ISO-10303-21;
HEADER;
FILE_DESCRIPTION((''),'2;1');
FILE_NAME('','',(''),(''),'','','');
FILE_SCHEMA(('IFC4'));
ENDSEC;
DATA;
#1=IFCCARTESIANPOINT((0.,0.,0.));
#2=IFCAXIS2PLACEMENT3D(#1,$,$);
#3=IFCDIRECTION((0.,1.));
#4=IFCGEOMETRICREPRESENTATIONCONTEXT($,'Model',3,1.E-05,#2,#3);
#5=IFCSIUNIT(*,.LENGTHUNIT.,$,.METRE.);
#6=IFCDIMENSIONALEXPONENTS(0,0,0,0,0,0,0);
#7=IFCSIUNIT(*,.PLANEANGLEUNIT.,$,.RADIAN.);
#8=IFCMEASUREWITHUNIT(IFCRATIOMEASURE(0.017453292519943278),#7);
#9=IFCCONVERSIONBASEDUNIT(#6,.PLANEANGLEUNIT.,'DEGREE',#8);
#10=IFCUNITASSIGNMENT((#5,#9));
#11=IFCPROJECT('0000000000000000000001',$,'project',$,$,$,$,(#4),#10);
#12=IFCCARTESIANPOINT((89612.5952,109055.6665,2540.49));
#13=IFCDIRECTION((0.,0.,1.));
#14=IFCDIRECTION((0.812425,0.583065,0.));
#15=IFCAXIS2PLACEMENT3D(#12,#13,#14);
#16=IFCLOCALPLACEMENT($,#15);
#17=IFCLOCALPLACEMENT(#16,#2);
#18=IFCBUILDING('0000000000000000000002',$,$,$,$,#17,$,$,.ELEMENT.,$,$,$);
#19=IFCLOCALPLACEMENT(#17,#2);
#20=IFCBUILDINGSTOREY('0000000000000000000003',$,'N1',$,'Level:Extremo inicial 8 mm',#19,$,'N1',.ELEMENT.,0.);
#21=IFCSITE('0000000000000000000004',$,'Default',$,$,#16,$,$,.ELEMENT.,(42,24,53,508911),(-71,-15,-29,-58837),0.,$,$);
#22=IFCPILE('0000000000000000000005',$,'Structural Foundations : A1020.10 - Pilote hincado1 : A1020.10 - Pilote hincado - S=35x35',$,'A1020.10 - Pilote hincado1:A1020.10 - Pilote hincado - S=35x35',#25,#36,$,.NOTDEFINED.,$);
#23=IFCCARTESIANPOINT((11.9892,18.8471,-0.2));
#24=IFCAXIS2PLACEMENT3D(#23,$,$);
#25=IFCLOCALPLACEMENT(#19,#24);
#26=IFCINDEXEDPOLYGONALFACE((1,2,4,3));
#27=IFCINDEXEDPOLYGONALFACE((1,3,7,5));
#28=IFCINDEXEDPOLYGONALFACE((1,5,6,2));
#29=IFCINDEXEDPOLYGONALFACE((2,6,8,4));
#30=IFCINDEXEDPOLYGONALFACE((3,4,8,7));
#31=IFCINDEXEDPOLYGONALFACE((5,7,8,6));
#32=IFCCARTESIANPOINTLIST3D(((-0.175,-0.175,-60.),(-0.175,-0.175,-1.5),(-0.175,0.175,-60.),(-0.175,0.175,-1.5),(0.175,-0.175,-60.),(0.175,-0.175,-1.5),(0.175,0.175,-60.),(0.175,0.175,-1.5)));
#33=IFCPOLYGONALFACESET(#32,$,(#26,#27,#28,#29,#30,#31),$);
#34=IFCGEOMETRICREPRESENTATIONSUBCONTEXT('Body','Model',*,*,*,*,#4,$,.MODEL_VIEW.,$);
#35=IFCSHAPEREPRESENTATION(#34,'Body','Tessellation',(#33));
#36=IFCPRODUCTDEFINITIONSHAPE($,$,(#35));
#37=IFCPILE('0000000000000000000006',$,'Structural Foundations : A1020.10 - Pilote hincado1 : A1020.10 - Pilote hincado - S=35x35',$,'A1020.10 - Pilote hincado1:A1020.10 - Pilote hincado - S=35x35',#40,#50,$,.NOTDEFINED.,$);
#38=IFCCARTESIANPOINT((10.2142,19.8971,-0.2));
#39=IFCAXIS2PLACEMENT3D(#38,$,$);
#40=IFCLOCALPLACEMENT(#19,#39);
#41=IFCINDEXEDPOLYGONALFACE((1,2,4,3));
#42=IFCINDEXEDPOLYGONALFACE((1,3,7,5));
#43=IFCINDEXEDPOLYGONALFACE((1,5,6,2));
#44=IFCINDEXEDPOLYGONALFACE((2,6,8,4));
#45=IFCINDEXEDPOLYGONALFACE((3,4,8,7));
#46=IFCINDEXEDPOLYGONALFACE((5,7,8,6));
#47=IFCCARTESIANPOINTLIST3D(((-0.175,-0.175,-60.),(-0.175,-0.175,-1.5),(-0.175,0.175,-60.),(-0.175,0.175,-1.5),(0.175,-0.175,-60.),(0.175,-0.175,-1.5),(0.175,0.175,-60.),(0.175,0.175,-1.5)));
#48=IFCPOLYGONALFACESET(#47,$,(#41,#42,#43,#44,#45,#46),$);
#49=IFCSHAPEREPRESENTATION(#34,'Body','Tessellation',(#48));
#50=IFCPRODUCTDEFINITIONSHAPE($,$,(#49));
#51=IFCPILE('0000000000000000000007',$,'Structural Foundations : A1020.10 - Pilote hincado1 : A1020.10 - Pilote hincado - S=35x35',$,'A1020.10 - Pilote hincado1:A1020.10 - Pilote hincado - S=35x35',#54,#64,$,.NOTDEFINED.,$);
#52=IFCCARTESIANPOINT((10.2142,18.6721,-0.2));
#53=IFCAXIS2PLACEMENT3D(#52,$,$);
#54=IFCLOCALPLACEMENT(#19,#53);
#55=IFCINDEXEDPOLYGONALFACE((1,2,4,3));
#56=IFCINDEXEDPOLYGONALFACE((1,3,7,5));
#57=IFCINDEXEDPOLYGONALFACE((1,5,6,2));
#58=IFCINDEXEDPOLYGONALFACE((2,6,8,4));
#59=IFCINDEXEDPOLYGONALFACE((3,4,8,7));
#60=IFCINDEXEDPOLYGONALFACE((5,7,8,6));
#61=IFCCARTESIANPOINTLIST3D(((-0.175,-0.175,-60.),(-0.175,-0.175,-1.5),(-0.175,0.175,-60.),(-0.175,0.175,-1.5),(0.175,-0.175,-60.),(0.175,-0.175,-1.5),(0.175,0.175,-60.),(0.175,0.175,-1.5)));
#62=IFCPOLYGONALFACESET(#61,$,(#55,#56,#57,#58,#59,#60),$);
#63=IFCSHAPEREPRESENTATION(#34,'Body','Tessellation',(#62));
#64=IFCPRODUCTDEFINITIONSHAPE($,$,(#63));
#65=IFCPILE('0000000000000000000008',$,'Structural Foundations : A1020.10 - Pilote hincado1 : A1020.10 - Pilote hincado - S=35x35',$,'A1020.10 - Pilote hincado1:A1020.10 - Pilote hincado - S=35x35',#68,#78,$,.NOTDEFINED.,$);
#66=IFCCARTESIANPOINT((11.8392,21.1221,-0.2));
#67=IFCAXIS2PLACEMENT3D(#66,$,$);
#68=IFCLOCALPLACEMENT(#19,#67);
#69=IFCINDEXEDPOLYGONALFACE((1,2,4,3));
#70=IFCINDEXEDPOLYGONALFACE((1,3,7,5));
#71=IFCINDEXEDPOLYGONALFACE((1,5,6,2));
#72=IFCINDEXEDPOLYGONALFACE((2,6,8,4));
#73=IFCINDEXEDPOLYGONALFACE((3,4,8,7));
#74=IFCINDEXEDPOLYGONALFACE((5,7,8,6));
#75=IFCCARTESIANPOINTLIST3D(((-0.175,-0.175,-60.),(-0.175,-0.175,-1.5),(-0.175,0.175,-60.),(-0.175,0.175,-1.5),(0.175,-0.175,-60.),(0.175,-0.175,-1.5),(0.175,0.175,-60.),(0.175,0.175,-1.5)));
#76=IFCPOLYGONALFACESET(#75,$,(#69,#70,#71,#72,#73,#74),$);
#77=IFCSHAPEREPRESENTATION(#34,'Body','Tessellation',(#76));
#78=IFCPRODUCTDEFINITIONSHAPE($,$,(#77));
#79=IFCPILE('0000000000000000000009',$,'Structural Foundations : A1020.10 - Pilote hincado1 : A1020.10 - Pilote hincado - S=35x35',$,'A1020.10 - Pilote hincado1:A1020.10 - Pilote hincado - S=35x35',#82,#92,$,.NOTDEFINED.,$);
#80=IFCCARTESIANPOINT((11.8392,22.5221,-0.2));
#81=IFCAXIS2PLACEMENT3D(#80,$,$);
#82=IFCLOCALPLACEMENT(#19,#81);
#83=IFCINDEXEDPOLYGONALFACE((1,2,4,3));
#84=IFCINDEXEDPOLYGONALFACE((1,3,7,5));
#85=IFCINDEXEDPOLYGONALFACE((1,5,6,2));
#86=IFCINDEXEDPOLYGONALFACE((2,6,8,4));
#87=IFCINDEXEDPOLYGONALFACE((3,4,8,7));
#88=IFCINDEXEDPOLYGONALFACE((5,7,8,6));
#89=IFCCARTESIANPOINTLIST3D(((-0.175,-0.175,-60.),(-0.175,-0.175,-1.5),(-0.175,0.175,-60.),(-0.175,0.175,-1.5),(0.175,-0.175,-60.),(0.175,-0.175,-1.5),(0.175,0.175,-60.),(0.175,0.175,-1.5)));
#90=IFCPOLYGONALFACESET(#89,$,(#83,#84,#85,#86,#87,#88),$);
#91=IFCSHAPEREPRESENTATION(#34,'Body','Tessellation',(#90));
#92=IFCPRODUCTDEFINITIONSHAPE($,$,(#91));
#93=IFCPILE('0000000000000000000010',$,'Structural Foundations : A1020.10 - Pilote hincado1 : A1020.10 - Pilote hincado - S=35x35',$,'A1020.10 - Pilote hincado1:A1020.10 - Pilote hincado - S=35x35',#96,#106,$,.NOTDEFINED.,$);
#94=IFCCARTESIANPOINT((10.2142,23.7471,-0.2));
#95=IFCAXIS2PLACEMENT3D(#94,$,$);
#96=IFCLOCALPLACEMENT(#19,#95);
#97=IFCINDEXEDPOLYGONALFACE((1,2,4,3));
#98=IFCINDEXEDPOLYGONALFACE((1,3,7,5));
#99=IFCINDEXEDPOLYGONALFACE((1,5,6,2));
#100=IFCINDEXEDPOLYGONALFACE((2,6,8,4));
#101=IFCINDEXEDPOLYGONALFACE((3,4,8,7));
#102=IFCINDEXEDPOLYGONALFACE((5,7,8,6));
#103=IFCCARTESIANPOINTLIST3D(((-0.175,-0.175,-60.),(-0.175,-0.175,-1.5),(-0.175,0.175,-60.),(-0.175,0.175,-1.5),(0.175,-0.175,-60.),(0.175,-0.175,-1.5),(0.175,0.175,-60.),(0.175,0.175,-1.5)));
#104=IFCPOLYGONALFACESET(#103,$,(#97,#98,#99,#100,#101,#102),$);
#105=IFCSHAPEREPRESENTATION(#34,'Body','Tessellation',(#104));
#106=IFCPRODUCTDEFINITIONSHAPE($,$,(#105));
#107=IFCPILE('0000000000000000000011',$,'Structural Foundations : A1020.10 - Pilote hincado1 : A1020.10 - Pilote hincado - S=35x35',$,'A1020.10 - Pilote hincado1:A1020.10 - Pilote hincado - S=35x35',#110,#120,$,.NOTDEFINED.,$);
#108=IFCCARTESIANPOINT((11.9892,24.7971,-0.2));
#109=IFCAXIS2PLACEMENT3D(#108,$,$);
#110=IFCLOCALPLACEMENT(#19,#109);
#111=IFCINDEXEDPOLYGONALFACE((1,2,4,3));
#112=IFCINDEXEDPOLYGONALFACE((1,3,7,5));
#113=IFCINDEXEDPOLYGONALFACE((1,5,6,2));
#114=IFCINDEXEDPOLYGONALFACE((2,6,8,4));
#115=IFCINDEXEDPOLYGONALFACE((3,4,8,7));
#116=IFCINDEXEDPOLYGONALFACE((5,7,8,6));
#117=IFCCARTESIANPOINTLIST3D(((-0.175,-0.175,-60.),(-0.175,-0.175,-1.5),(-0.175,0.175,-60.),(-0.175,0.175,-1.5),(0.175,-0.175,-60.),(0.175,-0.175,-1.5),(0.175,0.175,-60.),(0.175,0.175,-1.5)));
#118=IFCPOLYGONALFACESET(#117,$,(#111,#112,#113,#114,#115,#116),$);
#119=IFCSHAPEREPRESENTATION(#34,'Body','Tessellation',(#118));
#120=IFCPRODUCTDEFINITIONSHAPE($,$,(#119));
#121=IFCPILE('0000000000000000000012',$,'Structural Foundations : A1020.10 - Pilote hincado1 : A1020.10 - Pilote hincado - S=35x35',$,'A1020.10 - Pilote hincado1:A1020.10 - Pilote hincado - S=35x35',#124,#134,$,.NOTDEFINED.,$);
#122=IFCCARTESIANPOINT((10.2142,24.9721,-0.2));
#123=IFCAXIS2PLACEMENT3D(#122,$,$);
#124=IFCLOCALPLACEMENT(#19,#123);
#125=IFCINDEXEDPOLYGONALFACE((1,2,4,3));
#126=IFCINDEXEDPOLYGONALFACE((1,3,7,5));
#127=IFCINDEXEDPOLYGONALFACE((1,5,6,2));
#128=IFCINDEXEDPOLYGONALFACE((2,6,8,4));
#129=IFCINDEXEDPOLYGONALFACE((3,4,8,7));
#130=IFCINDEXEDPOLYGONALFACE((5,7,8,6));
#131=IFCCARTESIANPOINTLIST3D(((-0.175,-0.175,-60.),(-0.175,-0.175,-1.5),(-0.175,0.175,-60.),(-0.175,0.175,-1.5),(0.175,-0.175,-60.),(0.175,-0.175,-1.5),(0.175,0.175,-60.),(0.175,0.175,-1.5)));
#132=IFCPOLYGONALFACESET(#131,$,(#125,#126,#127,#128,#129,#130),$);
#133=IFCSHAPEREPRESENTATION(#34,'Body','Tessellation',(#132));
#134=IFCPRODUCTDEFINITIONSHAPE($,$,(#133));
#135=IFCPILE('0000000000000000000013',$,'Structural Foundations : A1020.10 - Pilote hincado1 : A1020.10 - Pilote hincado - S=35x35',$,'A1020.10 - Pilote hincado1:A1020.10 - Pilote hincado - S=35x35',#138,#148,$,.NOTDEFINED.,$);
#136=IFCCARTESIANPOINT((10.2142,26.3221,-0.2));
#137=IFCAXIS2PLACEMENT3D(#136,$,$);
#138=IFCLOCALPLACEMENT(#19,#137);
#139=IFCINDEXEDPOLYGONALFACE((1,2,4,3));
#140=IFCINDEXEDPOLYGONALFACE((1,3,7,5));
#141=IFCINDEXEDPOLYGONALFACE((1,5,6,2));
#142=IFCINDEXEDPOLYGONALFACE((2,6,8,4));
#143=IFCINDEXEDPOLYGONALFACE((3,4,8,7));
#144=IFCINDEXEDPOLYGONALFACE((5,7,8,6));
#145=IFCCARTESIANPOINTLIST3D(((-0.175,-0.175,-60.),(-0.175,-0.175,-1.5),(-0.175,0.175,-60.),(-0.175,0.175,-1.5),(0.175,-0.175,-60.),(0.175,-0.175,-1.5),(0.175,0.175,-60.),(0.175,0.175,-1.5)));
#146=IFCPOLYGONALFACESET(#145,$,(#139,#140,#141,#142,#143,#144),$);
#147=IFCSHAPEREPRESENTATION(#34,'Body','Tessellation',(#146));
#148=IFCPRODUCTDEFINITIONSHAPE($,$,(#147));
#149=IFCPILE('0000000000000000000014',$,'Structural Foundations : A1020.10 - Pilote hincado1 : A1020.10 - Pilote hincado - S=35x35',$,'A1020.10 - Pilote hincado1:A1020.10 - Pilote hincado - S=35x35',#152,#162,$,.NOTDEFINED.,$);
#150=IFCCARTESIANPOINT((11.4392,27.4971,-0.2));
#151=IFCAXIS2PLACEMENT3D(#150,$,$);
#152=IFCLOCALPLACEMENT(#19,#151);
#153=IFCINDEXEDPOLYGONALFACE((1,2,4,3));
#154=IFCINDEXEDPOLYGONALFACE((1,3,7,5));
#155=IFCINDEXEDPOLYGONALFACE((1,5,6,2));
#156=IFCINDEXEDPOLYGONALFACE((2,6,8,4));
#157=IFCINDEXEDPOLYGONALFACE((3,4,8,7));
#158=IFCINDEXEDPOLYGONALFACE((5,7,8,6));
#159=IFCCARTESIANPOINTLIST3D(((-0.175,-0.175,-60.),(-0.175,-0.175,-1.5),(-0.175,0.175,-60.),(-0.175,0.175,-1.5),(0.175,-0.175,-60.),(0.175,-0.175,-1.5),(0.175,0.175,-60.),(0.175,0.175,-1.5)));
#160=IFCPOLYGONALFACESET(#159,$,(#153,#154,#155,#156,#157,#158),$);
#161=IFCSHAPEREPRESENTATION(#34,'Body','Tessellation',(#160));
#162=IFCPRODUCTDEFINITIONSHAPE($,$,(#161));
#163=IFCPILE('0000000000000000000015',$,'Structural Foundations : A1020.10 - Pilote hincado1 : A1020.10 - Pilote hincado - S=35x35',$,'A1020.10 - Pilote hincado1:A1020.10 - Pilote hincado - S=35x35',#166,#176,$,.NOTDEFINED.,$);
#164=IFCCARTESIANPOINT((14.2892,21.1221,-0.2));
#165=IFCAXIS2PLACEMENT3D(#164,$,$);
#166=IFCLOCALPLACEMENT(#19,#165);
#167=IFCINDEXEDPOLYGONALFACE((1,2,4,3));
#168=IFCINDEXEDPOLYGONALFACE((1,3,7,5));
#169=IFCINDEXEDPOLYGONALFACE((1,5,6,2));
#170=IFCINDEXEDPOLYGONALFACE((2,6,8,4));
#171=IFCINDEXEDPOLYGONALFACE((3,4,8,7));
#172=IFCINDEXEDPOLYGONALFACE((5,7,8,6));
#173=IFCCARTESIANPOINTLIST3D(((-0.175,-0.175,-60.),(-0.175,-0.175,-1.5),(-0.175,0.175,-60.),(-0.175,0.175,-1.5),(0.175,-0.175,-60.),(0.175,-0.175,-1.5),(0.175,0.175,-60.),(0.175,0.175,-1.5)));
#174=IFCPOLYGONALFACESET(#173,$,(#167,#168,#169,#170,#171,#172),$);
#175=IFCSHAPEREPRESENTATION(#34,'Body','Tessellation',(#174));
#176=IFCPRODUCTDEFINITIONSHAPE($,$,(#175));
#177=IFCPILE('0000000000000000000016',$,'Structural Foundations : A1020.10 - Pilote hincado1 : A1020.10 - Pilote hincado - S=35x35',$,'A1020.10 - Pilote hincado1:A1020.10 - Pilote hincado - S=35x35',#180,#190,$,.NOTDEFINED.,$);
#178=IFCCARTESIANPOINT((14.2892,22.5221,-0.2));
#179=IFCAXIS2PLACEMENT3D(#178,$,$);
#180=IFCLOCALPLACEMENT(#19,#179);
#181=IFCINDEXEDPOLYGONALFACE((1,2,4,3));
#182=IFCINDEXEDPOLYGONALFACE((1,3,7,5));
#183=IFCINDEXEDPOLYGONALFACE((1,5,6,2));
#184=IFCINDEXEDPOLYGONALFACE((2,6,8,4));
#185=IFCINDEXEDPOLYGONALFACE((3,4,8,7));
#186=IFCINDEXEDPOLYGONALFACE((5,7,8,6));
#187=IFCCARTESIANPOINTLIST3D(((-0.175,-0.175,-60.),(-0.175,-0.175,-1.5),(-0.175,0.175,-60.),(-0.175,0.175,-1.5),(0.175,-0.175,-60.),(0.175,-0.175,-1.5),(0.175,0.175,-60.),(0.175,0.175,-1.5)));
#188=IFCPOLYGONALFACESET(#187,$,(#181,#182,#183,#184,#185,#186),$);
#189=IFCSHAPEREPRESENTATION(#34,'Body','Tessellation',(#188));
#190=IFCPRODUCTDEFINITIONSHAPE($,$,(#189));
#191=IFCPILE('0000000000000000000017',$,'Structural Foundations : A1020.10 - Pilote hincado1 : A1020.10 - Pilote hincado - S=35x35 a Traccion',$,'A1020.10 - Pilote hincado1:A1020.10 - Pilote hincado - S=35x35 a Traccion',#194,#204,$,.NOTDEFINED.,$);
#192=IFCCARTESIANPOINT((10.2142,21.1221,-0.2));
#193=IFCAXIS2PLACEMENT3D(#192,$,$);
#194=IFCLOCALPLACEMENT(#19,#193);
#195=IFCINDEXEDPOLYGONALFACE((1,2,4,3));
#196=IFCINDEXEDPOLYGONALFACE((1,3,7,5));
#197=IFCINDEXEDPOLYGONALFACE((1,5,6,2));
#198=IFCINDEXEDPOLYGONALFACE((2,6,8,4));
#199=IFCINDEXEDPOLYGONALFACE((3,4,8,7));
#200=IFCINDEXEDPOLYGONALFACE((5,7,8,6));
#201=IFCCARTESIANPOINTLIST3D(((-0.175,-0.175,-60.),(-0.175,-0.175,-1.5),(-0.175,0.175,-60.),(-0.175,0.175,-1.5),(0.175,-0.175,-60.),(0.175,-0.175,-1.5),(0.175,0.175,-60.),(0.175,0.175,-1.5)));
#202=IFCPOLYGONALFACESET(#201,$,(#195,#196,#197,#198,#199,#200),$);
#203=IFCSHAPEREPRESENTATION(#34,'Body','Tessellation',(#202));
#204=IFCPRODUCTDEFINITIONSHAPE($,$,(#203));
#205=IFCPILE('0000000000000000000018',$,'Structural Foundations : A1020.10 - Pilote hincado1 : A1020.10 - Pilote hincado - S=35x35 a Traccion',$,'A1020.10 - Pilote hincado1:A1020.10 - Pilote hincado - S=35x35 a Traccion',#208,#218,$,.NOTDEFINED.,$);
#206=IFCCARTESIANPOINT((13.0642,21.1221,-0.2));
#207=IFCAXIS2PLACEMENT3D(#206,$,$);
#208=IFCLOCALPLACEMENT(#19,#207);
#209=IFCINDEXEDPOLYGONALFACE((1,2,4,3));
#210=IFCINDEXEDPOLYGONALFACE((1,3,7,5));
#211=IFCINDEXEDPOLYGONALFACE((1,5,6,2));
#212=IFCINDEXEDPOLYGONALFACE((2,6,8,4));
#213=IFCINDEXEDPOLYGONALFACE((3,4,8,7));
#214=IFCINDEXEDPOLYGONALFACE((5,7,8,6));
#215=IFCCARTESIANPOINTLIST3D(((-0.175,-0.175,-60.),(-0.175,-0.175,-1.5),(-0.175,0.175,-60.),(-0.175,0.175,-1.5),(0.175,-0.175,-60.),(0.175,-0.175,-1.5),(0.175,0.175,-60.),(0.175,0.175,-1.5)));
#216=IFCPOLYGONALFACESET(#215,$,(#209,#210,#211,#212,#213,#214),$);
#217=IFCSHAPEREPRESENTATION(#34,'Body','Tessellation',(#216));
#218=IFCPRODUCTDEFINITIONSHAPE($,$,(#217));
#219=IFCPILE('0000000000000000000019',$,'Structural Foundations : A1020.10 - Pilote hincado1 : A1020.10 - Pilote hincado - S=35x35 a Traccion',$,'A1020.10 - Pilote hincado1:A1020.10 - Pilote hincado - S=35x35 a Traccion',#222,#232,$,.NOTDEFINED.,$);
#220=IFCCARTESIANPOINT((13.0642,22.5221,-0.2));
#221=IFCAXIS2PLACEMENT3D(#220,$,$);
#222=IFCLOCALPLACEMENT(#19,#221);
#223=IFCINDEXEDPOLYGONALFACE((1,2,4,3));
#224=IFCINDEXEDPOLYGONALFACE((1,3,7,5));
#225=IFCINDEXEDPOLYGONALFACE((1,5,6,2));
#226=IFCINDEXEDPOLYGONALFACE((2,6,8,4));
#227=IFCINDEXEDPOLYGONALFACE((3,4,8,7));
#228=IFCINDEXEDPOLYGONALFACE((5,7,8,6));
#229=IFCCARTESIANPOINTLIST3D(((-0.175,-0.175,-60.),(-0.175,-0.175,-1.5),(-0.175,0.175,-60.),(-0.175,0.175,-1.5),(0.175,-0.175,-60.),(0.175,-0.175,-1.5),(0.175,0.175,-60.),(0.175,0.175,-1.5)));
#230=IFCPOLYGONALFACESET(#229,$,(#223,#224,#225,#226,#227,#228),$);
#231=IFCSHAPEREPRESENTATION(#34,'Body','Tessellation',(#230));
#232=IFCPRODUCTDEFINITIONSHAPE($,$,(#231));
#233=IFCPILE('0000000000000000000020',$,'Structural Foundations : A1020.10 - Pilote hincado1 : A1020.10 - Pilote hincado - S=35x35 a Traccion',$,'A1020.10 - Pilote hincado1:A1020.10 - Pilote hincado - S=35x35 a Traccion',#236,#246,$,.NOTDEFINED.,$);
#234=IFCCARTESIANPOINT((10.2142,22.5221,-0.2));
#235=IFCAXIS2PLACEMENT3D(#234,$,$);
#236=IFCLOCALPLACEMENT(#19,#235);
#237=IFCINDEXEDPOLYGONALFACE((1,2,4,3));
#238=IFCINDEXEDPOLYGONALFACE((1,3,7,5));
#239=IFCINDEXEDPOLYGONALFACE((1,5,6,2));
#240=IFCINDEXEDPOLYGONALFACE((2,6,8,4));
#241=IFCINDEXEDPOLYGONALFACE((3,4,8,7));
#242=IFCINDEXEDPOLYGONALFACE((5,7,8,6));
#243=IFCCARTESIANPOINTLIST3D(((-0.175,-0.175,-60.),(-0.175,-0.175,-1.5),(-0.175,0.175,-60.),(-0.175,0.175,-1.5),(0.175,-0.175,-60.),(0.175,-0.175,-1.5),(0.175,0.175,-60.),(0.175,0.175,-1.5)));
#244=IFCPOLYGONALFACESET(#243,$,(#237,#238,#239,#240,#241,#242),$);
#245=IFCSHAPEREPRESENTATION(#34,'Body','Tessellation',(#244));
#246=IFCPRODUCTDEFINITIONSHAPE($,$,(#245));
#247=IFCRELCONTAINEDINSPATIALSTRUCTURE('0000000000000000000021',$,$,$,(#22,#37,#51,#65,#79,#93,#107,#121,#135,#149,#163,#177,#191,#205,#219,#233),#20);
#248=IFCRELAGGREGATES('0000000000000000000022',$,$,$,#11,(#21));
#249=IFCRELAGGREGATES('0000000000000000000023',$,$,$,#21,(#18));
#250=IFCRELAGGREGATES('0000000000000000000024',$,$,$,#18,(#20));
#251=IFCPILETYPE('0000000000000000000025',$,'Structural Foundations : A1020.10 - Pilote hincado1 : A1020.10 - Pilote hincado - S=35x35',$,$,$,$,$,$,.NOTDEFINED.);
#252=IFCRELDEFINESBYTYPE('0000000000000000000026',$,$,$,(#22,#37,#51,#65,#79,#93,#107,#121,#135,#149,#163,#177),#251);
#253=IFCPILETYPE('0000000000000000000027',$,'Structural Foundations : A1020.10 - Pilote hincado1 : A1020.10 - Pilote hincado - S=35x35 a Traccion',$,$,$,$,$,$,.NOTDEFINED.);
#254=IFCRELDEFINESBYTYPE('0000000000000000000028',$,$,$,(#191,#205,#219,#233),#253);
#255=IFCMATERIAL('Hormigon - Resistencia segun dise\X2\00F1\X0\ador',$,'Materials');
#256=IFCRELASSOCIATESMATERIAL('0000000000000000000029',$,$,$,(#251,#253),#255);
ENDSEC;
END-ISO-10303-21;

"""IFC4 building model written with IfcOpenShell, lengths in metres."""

from ifc_helpers import new_model, entity, si_unit, converted_unit, direction, frame, origin, origin_2d_with_axis, place, context, subcontext, project, spatial, polyline, segment, composite_curve, rectangle, outline, extrude, source, transform, mapped, material, material_profile, profile_set, type_object, type_shapes, element, save


model = new_model("IFC4")

# Units and contexts
model_context = context("Model", 3, precision=1e-05, world=origin(), true_north=direction((0.0, 1.0)))
body_context = subcontext(model_context, "Body", "Model", "MODEL_VIEW")
ifc_project = project(units=[si_unit("LENGTHUNIT", "METRE"), converted_unit("PLANEANGLEUNIT", "DEGREE", entity("IfcRatioMeasure", 0.017453292519943278), si_unit("PLANEANGLEUNIT", "RADIAN"), dimensions=[0, 0, 0, 0, 0, 0, 0])], contexts=[model_context])

# Site, building, storey
site_placement = place(None, frame((89612.5952, 109055.6665, 2540.49), z_axis=(0.0, 0.0, 1.0), x_axis=(0.812425, 0.583065, 0.0)))
site = spatial("IfcSite", under=ifc_project, at=site_placement, Name="Default", CompositionType="ELEMENT", RefLatitude=(42, 24, 53, 508911), RefLongitude=(-71, -15, -29, -58837), RefElevation=0.0)
building_placement = place(site_placement, origin())
building = spatial("IfcBuilding", under=site, at=building_placement, CompositionType="ELEMENT")
storey_placement = place(building_placement, origin())
storey = spatial("IfcBuildingStorey", under=building, at=storey_placement, Name="N1", ObjectType="Level:Extremo inicial 8 mm", LongName="N1", CompositionType="ELEMENT", Elevation=0.0)

# Piles
ifc_material_1 = material(Name="Hormigon - Resistencia segun diseñador", Category="Materials")
ifc_material_profile_1 = material_profile(ifc_material_1, outline(composite_curve([segment(polyline([(0.175, 0.175, -60.0), (0.175, -0.175, -60.0)]), True, "CONTINUOUS"), segment(polyline([(0.175, -0.175, -60.0), (-0.175, -0.175, -60.0)]), True, "CONTINUOUS"), segment(polyline([(-0.175, -0.175, -60.0), (-0.175, 0.175, -60.0)]), True, "CONTINUOUS"), segment(polyline([(-0.175, 0.175, -60.0), (0.175, 0.175, -60.0)]), True, "CONTINUOUS")], self_intersect=False), kind="CURVE"), Name="A1020.10 - Pilote hincado - S=35x35")
ifc_profile_set_1 = profile_set([ifc_material_profile_1], Name="A1020.10 - Pilote hincado - S=35x35")
pile_type_1 = type_object("IfcPileType", Name="Structural Foundations : A1020.10 - Pilote hincado1 : A1020.10 - Pilote hincado - S=35x35", PredefinedType="NOTDEFINED", material=ifc_profile_set_1)
shared_shape_1 = source(origin(), body_context, "Body", "SweptSolid", [
    extrude(rectangle(XDim=0.35, YDim=0.35, at=origin_2d_with_axis()), frame((0.0, 0.0, -60.0), z_axis=(0.0, 0.0, 1.0), x_axis=(0.0, -1.0, 0.0)), (0.0, 0.0, 1.0), 58.5),
])
type_shapes(pile_type_1, [shared_shape_1])
for number, where, name in (
    (1, (11.9892, 18.8471, -0.2), "Structural Foundations : A1020.10 - Pilote hincado1 : A1020.10 - Pilote hincado - S=35x35"),
    (2, (10.2142, 19.8971, -0.2), "Structural Foundations : A1020.10 - Pilote hincado1 : A1020.10 - Pilote hincado - S=35x35"),
    (3, (10.2142, 18.6721, -0.2), "Structural Foundations : A1020.10 - Pilote hincado1 : A1020.10 - Pilote hincado - S=35x35"),
    (4, (11.8392, 21.1221, -0.2), "Structural Foundations : A1020.10 - Pilote hincado1 : A1020.10 - Pilote hincado - S=35x35"),
    (5, (11.8392, 22.5221, -0.2), "Structural Foundations : A1020.10 - Pilote hincado1 : A1020.10 - Pilote hincado - S=35x35"),
    (6, (10.2142, 23.7471, -0.2), "Structural Foundations : A1020.10 - Pilote hincado1 : A1020.10 - Pilote hincado - S=35x35"),
    (7, (11.9892, 24.7971, -0.2), "Structural Foundations : A1020.10 - Pilote hincado1 : A1020.10 - Pilote hincado - S=35x35"),
    (8, (10.2142, 24.9721, -0.2), "Structural Foundations : A1020.10 - Pilote hincado1 : A1020.10 - Pilote hincado - S=35x35"),
    (9, (10.2142, 26.3221, -0.2), "Structural Foundations : A1020.10 - Pilote hincado1 : A1020.10 - Pilote hincado - S=35x35"),
    (10, (11.4392, 27.4971, -0.2), "Structural Foundations : A1020.10 - Pilote hincado1 : A1020.10 - Pilote hincado - S=35x35"),
    (11, (14.2892, 21.1221, -0.2), "Structural Foundations : A1020.10 - Pilote hincado1 : A1020.10 - Pilote hincado - S=35x35"),
    (12, (14.2892, 22.5221, -0.2), "Structural Foundations : A1020.10 - Pilote hincado1 : A1020.10 - Pilote hincado - S=35x35"),
):
    element("IfcPile", number, at=place(storey_placement, frame(where)), inside=storey, type_object=pile_type_1, Name=name, ObjectType="A1020.10 - Pilote hincado1:A1020.10 - Pilote hincado - S=35x35", PredefinedType="NOTDEFINED", context=body_context, shape_type="MappedRepresentation", body=[
        mapped(shared_shape_1, transform((0.0, 0.0, 0.0), scale=1.0)),
    ])
ifc_material_profile_2 = material_profile(ifc_material_1, outline(composite_curve([segment(polyline([(0.175, 0.175, -60.0), (0.175, -0.175, -60.0)]), True, "CONTINUOUS"), segment(polyline([(0.175, -0.175, -60.0), (-0.175, -0.175, -60.0)]), True, "CONTINUOUS"), segment(polyline([(-0.175, -0.175, -60.0), (-0.175, 0.175, -60.0)]), True, "CONTINUOUS"), segment(polyline([(-0.175, 0.175, -60.0), (0.175, 0.175, -60.0)]), True, "CONTINUOUS")], self_intersect=False), kind="CURVE"), Name="A1020.10 - Pilote hincado - S=35x35 a Traccion")
ifc_profile_set_2 = profile_set([ifc_material_profile_2], Name="A1020.10 - Pilote hincado - S=35x35 a Traccion")
pile_type_2 = type_object("IfcPileType", Name="Structural Foundations : A1020.10 - Pilote hincado1 : A1020.10 - Pilote hincado - S=35x35 a Traccion", PredefinedType="NOTDEFINED", material=ifc_profile_set_2)
shared_shape_2 = source(origin(), body_context, "Body", "SweptSolid", [
    extrude(rectangle(XDim=0.35, YDim=0.35, at=origin_2d_with_axis()), frame((0.0, 0.0, -60.0), z_axis=(0.0, 0.0, 1.0), x_axis=(0.0, -1.0, 0.0)), (0.0, 0.0, 1.0), 58.5),
])
type_shapes(pile_type_2, [shared_shape_2])
for number, where, name in (
    (13, (10.2142, 21.1221, -0.2), "Structural Foundations : A1020.10 - Pilote hincado1 : A1020.10 - Pilote hincado - S=35x35 a Traccion"),
    (14, (13.0642, 21.1221, -0.2), "Structural Foundations : A1020.10 - Pilote hincado1 : A1020.10 - Pilote hincado - S=35x35 a Traccion"),
    (15, (13.0642, 22.5221, -0.2), "Structural Foundations : A1020.10 - Pilote hincado1 : A1020.10 - Pilote hincado - S=35x35 a Traccion"),
    (16, (10.2142, 22.5221, -0.2), "Structural Foundations : A1020.10 - Pilote hincado1 : A1020.10 - Pilote hincado - S=35x35 a Traccion"),
):
    element("IfcPile", number, at=place(storey_placement, frame(where)), inside=storey, type_object=pile_type_2, Name=name, ObjectType="A1020.10 - Pilote hincado1:A1020.10 - Pilote hincado - S=35x35 a Traccion", PredefinedType="NOTDEFINED", context=body_context, shape_type="MappedRepresentation", body=[
        mapped(shared_shape_2, transform((0.0, 0.0, 0.0), scale=1.0)),
    ])

save(model, "model.ifc")
